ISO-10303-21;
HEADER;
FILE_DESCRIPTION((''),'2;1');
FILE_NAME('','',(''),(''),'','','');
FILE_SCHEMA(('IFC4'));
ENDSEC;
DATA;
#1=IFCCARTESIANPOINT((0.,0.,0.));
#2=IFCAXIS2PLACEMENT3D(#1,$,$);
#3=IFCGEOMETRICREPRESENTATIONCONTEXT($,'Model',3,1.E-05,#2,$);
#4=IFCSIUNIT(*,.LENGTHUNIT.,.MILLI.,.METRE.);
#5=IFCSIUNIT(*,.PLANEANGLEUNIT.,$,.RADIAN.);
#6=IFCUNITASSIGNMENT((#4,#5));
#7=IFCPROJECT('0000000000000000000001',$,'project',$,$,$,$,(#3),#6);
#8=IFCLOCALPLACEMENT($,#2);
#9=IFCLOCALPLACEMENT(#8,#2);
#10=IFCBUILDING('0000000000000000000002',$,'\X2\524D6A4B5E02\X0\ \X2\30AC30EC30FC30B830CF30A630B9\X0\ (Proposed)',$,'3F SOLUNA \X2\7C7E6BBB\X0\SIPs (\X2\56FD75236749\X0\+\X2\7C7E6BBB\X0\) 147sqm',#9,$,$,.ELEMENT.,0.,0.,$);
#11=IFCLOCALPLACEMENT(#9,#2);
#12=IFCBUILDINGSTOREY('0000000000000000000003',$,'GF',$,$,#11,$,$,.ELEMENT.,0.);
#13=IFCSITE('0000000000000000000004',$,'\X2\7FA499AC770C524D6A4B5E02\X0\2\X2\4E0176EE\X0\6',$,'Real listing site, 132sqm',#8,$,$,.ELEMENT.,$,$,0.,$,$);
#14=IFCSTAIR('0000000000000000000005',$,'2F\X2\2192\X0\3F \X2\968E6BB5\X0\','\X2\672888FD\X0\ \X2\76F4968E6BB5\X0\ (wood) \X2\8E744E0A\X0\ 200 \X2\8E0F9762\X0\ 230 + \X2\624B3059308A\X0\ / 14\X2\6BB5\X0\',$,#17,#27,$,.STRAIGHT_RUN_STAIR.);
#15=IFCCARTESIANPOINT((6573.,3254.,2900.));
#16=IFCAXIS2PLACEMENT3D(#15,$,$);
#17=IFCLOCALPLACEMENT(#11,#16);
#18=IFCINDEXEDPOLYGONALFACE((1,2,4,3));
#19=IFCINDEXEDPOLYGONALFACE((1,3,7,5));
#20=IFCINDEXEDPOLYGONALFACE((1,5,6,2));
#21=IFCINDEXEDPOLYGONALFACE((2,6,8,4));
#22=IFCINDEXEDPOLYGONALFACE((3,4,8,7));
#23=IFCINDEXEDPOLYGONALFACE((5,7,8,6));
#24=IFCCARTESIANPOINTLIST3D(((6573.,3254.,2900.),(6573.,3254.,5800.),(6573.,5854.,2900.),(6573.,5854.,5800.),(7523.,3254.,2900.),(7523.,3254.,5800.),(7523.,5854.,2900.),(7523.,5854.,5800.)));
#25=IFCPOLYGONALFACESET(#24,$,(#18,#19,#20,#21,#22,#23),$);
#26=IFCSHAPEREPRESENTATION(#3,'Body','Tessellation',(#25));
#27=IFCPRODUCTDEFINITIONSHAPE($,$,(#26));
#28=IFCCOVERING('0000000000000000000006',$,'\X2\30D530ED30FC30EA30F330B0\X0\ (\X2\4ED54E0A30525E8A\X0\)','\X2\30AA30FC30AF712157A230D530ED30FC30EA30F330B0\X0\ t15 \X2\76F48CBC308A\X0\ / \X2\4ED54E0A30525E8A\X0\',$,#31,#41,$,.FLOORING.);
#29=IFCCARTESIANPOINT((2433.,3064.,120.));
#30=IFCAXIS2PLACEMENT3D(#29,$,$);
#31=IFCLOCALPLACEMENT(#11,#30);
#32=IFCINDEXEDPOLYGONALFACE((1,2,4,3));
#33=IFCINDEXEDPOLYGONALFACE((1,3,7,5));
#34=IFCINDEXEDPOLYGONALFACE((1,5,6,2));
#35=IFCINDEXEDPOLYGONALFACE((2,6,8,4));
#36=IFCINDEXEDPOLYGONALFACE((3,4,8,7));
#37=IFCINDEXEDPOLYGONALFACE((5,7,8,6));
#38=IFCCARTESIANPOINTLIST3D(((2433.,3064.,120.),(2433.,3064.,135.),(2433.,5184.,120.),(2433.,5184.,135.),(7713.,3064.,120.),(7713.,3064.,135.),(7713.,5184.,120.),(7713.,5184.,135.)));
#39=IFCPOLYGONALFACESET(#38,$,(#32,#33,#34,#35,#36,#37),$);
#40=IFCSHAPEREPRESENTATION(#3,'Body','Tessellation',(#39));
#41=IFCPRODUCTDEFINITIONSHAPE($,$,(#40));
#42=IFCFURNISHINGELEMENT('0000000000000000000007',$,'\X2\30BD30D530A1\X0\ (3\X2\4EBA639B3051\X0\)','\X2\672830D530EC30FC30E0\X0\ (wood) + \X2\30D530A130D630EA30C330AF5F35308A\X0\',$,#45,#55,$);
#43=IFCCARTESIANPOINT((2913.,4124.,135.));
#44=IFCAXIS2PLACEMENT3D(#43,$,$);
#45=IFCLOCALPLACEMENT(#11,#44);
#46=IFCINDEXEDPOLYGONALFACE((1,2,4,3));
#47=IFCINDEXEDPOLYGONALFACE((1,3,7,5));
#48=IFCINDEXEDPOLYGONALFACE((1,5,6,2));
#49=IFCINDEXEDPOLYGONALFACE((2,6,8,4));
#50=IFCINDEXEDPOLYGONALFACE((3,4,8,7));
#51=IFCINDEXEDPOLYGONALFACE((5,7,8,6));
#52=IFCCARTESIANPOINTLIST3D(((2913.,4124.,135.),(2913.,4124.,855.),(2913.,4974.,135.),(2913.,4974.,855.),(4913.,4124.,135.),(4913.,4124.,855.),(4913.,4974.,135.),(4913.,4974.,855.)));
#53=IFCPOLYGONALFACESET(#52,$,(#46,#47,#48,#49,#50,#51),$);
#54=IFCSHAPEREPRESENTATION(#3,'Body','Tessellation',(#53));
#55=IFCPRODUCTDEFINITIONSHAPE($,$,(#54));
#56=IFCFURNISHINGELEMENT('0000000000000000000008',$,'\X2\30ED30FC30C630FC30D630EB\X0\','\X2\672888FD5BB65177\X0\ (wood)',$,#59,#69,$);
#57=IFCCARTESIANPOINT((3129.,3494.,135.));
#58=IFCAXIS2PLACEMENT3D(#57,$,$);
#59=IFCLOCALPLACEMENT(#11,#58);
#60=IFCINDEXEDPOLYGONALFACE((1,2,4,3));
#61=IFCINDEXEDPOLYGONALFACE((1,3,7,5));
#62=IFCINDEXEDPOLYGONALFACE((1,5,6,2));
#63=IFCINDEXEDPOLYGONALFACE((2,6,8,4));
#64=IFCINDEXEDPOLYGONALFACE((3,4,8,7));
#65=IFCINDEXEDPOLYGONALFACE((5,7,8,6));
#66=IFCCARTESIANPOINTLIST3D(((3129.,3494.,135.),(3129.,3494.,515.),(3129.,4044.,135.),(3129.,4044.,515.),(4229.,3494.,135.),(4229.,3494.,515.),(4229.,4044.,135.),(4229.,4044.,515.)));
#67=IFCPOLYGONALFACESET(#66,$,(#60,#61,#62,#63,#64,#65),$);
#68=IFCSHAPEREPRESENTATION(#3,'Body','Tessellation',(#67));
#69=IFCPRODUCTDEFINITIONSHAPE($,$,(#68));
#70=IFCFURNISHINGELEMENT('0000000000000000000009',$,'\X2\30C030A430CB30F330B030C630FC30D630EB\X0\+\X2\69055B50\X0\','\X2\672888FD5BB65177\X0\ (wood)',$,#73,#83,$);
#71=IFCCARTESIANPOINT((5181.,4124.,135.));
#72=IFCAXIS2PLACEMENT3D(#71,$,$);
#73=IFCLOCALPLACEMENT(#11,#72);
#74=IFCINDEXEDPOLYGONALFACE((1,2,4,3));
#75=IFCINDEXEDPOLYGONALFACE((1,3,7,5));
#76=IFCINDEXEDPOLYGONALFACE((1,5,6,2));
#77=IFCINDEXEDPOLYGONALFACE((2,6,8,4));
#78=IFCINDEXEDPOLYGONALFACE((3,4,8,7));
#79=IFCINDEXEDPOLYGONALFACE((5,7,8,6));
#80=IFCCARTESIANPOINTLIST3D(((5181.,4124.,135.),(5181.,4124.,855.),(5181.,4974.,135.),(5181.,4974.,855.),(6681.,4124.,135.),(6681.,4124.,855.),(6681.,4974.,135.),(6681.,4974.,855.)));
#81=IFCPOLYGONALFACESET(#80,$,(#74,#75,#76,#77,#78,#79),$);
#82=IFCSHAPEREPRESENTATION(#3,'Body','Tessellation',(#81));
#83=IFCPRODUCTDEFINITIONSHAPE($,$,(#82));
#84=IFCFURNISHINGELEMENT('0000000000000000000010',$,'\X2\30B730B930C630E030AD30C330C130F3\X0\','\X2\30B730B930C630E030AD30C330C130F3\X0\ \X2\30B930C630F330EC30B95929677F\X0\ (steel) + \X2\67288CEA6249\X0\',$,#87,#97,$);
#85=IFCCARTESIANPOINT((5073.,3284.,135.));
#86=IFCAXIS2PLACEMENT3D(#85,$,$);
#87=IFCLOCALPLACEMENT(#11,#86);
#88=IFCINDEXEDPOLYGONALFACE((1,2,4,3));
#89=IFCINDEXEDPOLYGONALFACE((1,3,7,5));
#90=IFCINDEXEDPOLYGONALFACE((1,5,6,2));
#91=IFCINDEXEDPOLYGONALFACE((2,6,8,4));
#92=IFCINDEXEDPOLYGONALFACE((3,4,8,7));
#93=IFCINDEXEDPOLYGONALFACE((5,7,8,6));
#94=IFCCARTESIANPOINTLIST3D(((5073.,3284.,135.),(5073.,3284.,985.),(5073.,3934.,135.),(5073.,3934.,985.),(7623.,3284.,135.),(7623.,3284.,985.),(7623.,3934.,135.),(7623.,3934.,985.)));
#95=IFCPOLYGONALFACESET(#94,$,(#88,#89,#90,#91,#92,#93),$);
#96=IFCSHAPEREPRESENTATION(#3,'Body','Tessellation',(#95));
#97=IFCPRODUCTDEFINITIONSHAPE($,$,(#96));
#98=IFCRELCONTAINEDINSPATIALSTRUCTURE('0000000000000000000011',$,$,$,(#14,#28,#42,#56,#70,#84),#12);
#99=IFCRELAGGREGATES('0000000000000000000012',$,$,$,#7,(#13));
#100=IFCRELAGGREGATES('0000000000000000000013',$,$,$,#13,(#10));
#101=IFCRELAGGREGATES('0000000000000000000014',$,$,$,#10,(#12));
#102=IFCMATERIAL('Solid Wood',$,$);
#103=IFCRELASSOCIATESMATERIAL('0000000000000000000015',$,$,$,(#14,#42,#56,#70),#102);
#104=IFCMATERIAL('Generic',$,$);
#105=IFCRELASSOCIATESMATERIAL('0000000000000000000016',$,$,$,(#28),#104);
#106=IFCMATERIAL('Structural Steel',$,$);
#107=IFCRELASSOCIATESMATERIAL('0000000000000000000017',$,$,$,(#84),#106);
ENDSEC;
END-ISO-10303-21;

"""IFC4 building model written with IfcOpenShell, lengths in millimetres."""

from ifc_helpers import new_model, si_unit, frame, frame_2d, origin, place, context, project, spatial, rectangle, extrude, material, element, save


model = new_model("IFC4")

# Units and contexts
model_context = context("Model", 3, precision=1e-05, world=origin())
ifc_project = project(units=[si_unit("LENGTHUNIT", "METRE", prefix="MILLI"), si_unit("PLANEANGLEUNIT", "RADIAN")], contexts=[model_context])

# Site, building, storey
site_placement = place(None, origin())
site = spatial("IfcSite", under=ifc_project, at=site_placement, Name="群馬県前橋市2丁目6", ObjectType="Real listing site, 132sqm", CompositionType="ELEMENT", RefElevation=0.0)
building_placement = place(site_placement, origin())
building = spatial("IfcBuilding", under=site, at=building_placement, Name="前橋市 ガレージハウス (Proposed)", ObjectType="3F SOLUNA 籾殻SIPs (国産杉+籾殻) 147sqm", CompositionType="ELEMENT", ElevationOfRefHeight=0.0, ElevationOfTerrain=0.0)
storey_placement = place(building_placement, origin())
storey = spatial("IfcBuildingStorey", under=building, at=storey_placement, Name="GF", CompositionType="ELEMENT", Elevation=0.0)

# Shared definitions
ifc_material_1 = material(Name="Solid Wood")
ifc_material_2 = material(Name="Generic")

# Stair
stair_1_placement = place(storey_placement, frame((6573.0, 3254.0, 2900.0)))
element("IfcStair", 1, at=stair_1_placement, inside=storey, material=ifc_material_1, Name="2F→3F 階段", Description="木製 直階段 (wood) 蹴上 200 踏面 230 + 手すり / 14段", PredefinedType="STRAIGHT_RUN_STAIR", context=model_context, shape_type="SweptSolid", body=[
    extrude(rectangle(XDim=950.0, YDim=2600.0, at=frame_2d((475.0, 1300.0))), frame((6573.0, 3254.0, 2900.0)), (0.0, 0.0, 1.0), 2900.0),
])

# Covering
covering_placement = place(storey_placement, frame((2433.0, 3064.0, 120.0)))
element("IfcCovering", 2, at=covering_placement, inside=storey, material=ifc_material_2, Name="フローリング (仕上げ床)", Description="オーク無垢フローリング t15 直貼り / 仕上げ床", PredefinedType="FLOORING", context=model_context, shape_type="SweptSolid", body=[
    extrude(rectangle(XDim=5280.0, YDim=2120.0, at=frame_2d((2640.0, 1060.0))), frame((2433.0, 3064.0, 120.0)), (0.0, 0.0, 1.0), 15.0),
])

# Furnishing elements
furnishing_1_placement = place(storey_placement, frame((2913.0, 4124.0, 135.0)))
element("IfcFurnishingElement", 3, at=furnishing_1_placement, inside=storey, material=ifc_material_1, Name="ソファ (3人掛け)", Description="木フレーム (wood) + ファブリック張り", context=model_context, shape_type="SweptSolid", body=[
    extrude(rectangle(XDim=2000.0, YDim=850.0, at=frame_2d((1000.0, 425.0))), frame((2913.0, 4124.0, 135.0)), (0.0, 0.0, 1.0), 720.0),
])
furnishing_2_placement = place(storey_placement, frame((3129.0, 3494.0, 135.0)))
element("IfcFurnishingElement", 4, at=furnishing_2_placement, inside=storey, material=ifc_material_1, Name="ローテーブル", Description="木製家具 (wood)", context=model_context, shape_type="SweptSolid", body=[
    extrude(rectangle(XDim=1100.0, YDim=550.0, at=frame_2d((550.0, 275.0))), frame((3129.0, 3494.0, 135.0)), (0.0, 0.0, 1.0), 380.0),
])
furnishing_3_placement = place(storey_placement, frame((5181.0, 4124.0, 135.0)))
element("IfcFurnishingElement", 5, at=furnishing_3_placement, inside=storey, material=ifc_material_1, Name="ダイニングテーブル+椅子", Description="木製家具 (wood)", context=model_context, shape_type="SweptSolid", body=[
    extrude(rectangle(XDim=1500.0, YDim=850.0, at=frame_2d((750.0, 425.0))), frame((5181.0, 4124.0, 135.0)), (0.0, 0.0, 1.0), 720.0),
])
ifc_material_3 = material(Name="Structural Steel")
furnishing_4_placement = place(storey_placement, frame((5073.0, 3284.0, 135.0)))
element("IfcFurnishingElement", 6, at=furnishing_4_placement, inside=storey, material=ifc_material_3, Name="システムキッチン", Description="システムキッチン ステンレス天板 (steel) + 木質扉", context=model_context, shape_type="SweptSolid", body=[
    extrude(rectangle(XDim=2550.0, YDim=650.0, at=frame_2d((1275.0, 325.0))), frame((5073.0, 3284.0, 135.0)), (0.0, 0.0, 1.0), 850.0),
])

save(model, "model.ifc")
